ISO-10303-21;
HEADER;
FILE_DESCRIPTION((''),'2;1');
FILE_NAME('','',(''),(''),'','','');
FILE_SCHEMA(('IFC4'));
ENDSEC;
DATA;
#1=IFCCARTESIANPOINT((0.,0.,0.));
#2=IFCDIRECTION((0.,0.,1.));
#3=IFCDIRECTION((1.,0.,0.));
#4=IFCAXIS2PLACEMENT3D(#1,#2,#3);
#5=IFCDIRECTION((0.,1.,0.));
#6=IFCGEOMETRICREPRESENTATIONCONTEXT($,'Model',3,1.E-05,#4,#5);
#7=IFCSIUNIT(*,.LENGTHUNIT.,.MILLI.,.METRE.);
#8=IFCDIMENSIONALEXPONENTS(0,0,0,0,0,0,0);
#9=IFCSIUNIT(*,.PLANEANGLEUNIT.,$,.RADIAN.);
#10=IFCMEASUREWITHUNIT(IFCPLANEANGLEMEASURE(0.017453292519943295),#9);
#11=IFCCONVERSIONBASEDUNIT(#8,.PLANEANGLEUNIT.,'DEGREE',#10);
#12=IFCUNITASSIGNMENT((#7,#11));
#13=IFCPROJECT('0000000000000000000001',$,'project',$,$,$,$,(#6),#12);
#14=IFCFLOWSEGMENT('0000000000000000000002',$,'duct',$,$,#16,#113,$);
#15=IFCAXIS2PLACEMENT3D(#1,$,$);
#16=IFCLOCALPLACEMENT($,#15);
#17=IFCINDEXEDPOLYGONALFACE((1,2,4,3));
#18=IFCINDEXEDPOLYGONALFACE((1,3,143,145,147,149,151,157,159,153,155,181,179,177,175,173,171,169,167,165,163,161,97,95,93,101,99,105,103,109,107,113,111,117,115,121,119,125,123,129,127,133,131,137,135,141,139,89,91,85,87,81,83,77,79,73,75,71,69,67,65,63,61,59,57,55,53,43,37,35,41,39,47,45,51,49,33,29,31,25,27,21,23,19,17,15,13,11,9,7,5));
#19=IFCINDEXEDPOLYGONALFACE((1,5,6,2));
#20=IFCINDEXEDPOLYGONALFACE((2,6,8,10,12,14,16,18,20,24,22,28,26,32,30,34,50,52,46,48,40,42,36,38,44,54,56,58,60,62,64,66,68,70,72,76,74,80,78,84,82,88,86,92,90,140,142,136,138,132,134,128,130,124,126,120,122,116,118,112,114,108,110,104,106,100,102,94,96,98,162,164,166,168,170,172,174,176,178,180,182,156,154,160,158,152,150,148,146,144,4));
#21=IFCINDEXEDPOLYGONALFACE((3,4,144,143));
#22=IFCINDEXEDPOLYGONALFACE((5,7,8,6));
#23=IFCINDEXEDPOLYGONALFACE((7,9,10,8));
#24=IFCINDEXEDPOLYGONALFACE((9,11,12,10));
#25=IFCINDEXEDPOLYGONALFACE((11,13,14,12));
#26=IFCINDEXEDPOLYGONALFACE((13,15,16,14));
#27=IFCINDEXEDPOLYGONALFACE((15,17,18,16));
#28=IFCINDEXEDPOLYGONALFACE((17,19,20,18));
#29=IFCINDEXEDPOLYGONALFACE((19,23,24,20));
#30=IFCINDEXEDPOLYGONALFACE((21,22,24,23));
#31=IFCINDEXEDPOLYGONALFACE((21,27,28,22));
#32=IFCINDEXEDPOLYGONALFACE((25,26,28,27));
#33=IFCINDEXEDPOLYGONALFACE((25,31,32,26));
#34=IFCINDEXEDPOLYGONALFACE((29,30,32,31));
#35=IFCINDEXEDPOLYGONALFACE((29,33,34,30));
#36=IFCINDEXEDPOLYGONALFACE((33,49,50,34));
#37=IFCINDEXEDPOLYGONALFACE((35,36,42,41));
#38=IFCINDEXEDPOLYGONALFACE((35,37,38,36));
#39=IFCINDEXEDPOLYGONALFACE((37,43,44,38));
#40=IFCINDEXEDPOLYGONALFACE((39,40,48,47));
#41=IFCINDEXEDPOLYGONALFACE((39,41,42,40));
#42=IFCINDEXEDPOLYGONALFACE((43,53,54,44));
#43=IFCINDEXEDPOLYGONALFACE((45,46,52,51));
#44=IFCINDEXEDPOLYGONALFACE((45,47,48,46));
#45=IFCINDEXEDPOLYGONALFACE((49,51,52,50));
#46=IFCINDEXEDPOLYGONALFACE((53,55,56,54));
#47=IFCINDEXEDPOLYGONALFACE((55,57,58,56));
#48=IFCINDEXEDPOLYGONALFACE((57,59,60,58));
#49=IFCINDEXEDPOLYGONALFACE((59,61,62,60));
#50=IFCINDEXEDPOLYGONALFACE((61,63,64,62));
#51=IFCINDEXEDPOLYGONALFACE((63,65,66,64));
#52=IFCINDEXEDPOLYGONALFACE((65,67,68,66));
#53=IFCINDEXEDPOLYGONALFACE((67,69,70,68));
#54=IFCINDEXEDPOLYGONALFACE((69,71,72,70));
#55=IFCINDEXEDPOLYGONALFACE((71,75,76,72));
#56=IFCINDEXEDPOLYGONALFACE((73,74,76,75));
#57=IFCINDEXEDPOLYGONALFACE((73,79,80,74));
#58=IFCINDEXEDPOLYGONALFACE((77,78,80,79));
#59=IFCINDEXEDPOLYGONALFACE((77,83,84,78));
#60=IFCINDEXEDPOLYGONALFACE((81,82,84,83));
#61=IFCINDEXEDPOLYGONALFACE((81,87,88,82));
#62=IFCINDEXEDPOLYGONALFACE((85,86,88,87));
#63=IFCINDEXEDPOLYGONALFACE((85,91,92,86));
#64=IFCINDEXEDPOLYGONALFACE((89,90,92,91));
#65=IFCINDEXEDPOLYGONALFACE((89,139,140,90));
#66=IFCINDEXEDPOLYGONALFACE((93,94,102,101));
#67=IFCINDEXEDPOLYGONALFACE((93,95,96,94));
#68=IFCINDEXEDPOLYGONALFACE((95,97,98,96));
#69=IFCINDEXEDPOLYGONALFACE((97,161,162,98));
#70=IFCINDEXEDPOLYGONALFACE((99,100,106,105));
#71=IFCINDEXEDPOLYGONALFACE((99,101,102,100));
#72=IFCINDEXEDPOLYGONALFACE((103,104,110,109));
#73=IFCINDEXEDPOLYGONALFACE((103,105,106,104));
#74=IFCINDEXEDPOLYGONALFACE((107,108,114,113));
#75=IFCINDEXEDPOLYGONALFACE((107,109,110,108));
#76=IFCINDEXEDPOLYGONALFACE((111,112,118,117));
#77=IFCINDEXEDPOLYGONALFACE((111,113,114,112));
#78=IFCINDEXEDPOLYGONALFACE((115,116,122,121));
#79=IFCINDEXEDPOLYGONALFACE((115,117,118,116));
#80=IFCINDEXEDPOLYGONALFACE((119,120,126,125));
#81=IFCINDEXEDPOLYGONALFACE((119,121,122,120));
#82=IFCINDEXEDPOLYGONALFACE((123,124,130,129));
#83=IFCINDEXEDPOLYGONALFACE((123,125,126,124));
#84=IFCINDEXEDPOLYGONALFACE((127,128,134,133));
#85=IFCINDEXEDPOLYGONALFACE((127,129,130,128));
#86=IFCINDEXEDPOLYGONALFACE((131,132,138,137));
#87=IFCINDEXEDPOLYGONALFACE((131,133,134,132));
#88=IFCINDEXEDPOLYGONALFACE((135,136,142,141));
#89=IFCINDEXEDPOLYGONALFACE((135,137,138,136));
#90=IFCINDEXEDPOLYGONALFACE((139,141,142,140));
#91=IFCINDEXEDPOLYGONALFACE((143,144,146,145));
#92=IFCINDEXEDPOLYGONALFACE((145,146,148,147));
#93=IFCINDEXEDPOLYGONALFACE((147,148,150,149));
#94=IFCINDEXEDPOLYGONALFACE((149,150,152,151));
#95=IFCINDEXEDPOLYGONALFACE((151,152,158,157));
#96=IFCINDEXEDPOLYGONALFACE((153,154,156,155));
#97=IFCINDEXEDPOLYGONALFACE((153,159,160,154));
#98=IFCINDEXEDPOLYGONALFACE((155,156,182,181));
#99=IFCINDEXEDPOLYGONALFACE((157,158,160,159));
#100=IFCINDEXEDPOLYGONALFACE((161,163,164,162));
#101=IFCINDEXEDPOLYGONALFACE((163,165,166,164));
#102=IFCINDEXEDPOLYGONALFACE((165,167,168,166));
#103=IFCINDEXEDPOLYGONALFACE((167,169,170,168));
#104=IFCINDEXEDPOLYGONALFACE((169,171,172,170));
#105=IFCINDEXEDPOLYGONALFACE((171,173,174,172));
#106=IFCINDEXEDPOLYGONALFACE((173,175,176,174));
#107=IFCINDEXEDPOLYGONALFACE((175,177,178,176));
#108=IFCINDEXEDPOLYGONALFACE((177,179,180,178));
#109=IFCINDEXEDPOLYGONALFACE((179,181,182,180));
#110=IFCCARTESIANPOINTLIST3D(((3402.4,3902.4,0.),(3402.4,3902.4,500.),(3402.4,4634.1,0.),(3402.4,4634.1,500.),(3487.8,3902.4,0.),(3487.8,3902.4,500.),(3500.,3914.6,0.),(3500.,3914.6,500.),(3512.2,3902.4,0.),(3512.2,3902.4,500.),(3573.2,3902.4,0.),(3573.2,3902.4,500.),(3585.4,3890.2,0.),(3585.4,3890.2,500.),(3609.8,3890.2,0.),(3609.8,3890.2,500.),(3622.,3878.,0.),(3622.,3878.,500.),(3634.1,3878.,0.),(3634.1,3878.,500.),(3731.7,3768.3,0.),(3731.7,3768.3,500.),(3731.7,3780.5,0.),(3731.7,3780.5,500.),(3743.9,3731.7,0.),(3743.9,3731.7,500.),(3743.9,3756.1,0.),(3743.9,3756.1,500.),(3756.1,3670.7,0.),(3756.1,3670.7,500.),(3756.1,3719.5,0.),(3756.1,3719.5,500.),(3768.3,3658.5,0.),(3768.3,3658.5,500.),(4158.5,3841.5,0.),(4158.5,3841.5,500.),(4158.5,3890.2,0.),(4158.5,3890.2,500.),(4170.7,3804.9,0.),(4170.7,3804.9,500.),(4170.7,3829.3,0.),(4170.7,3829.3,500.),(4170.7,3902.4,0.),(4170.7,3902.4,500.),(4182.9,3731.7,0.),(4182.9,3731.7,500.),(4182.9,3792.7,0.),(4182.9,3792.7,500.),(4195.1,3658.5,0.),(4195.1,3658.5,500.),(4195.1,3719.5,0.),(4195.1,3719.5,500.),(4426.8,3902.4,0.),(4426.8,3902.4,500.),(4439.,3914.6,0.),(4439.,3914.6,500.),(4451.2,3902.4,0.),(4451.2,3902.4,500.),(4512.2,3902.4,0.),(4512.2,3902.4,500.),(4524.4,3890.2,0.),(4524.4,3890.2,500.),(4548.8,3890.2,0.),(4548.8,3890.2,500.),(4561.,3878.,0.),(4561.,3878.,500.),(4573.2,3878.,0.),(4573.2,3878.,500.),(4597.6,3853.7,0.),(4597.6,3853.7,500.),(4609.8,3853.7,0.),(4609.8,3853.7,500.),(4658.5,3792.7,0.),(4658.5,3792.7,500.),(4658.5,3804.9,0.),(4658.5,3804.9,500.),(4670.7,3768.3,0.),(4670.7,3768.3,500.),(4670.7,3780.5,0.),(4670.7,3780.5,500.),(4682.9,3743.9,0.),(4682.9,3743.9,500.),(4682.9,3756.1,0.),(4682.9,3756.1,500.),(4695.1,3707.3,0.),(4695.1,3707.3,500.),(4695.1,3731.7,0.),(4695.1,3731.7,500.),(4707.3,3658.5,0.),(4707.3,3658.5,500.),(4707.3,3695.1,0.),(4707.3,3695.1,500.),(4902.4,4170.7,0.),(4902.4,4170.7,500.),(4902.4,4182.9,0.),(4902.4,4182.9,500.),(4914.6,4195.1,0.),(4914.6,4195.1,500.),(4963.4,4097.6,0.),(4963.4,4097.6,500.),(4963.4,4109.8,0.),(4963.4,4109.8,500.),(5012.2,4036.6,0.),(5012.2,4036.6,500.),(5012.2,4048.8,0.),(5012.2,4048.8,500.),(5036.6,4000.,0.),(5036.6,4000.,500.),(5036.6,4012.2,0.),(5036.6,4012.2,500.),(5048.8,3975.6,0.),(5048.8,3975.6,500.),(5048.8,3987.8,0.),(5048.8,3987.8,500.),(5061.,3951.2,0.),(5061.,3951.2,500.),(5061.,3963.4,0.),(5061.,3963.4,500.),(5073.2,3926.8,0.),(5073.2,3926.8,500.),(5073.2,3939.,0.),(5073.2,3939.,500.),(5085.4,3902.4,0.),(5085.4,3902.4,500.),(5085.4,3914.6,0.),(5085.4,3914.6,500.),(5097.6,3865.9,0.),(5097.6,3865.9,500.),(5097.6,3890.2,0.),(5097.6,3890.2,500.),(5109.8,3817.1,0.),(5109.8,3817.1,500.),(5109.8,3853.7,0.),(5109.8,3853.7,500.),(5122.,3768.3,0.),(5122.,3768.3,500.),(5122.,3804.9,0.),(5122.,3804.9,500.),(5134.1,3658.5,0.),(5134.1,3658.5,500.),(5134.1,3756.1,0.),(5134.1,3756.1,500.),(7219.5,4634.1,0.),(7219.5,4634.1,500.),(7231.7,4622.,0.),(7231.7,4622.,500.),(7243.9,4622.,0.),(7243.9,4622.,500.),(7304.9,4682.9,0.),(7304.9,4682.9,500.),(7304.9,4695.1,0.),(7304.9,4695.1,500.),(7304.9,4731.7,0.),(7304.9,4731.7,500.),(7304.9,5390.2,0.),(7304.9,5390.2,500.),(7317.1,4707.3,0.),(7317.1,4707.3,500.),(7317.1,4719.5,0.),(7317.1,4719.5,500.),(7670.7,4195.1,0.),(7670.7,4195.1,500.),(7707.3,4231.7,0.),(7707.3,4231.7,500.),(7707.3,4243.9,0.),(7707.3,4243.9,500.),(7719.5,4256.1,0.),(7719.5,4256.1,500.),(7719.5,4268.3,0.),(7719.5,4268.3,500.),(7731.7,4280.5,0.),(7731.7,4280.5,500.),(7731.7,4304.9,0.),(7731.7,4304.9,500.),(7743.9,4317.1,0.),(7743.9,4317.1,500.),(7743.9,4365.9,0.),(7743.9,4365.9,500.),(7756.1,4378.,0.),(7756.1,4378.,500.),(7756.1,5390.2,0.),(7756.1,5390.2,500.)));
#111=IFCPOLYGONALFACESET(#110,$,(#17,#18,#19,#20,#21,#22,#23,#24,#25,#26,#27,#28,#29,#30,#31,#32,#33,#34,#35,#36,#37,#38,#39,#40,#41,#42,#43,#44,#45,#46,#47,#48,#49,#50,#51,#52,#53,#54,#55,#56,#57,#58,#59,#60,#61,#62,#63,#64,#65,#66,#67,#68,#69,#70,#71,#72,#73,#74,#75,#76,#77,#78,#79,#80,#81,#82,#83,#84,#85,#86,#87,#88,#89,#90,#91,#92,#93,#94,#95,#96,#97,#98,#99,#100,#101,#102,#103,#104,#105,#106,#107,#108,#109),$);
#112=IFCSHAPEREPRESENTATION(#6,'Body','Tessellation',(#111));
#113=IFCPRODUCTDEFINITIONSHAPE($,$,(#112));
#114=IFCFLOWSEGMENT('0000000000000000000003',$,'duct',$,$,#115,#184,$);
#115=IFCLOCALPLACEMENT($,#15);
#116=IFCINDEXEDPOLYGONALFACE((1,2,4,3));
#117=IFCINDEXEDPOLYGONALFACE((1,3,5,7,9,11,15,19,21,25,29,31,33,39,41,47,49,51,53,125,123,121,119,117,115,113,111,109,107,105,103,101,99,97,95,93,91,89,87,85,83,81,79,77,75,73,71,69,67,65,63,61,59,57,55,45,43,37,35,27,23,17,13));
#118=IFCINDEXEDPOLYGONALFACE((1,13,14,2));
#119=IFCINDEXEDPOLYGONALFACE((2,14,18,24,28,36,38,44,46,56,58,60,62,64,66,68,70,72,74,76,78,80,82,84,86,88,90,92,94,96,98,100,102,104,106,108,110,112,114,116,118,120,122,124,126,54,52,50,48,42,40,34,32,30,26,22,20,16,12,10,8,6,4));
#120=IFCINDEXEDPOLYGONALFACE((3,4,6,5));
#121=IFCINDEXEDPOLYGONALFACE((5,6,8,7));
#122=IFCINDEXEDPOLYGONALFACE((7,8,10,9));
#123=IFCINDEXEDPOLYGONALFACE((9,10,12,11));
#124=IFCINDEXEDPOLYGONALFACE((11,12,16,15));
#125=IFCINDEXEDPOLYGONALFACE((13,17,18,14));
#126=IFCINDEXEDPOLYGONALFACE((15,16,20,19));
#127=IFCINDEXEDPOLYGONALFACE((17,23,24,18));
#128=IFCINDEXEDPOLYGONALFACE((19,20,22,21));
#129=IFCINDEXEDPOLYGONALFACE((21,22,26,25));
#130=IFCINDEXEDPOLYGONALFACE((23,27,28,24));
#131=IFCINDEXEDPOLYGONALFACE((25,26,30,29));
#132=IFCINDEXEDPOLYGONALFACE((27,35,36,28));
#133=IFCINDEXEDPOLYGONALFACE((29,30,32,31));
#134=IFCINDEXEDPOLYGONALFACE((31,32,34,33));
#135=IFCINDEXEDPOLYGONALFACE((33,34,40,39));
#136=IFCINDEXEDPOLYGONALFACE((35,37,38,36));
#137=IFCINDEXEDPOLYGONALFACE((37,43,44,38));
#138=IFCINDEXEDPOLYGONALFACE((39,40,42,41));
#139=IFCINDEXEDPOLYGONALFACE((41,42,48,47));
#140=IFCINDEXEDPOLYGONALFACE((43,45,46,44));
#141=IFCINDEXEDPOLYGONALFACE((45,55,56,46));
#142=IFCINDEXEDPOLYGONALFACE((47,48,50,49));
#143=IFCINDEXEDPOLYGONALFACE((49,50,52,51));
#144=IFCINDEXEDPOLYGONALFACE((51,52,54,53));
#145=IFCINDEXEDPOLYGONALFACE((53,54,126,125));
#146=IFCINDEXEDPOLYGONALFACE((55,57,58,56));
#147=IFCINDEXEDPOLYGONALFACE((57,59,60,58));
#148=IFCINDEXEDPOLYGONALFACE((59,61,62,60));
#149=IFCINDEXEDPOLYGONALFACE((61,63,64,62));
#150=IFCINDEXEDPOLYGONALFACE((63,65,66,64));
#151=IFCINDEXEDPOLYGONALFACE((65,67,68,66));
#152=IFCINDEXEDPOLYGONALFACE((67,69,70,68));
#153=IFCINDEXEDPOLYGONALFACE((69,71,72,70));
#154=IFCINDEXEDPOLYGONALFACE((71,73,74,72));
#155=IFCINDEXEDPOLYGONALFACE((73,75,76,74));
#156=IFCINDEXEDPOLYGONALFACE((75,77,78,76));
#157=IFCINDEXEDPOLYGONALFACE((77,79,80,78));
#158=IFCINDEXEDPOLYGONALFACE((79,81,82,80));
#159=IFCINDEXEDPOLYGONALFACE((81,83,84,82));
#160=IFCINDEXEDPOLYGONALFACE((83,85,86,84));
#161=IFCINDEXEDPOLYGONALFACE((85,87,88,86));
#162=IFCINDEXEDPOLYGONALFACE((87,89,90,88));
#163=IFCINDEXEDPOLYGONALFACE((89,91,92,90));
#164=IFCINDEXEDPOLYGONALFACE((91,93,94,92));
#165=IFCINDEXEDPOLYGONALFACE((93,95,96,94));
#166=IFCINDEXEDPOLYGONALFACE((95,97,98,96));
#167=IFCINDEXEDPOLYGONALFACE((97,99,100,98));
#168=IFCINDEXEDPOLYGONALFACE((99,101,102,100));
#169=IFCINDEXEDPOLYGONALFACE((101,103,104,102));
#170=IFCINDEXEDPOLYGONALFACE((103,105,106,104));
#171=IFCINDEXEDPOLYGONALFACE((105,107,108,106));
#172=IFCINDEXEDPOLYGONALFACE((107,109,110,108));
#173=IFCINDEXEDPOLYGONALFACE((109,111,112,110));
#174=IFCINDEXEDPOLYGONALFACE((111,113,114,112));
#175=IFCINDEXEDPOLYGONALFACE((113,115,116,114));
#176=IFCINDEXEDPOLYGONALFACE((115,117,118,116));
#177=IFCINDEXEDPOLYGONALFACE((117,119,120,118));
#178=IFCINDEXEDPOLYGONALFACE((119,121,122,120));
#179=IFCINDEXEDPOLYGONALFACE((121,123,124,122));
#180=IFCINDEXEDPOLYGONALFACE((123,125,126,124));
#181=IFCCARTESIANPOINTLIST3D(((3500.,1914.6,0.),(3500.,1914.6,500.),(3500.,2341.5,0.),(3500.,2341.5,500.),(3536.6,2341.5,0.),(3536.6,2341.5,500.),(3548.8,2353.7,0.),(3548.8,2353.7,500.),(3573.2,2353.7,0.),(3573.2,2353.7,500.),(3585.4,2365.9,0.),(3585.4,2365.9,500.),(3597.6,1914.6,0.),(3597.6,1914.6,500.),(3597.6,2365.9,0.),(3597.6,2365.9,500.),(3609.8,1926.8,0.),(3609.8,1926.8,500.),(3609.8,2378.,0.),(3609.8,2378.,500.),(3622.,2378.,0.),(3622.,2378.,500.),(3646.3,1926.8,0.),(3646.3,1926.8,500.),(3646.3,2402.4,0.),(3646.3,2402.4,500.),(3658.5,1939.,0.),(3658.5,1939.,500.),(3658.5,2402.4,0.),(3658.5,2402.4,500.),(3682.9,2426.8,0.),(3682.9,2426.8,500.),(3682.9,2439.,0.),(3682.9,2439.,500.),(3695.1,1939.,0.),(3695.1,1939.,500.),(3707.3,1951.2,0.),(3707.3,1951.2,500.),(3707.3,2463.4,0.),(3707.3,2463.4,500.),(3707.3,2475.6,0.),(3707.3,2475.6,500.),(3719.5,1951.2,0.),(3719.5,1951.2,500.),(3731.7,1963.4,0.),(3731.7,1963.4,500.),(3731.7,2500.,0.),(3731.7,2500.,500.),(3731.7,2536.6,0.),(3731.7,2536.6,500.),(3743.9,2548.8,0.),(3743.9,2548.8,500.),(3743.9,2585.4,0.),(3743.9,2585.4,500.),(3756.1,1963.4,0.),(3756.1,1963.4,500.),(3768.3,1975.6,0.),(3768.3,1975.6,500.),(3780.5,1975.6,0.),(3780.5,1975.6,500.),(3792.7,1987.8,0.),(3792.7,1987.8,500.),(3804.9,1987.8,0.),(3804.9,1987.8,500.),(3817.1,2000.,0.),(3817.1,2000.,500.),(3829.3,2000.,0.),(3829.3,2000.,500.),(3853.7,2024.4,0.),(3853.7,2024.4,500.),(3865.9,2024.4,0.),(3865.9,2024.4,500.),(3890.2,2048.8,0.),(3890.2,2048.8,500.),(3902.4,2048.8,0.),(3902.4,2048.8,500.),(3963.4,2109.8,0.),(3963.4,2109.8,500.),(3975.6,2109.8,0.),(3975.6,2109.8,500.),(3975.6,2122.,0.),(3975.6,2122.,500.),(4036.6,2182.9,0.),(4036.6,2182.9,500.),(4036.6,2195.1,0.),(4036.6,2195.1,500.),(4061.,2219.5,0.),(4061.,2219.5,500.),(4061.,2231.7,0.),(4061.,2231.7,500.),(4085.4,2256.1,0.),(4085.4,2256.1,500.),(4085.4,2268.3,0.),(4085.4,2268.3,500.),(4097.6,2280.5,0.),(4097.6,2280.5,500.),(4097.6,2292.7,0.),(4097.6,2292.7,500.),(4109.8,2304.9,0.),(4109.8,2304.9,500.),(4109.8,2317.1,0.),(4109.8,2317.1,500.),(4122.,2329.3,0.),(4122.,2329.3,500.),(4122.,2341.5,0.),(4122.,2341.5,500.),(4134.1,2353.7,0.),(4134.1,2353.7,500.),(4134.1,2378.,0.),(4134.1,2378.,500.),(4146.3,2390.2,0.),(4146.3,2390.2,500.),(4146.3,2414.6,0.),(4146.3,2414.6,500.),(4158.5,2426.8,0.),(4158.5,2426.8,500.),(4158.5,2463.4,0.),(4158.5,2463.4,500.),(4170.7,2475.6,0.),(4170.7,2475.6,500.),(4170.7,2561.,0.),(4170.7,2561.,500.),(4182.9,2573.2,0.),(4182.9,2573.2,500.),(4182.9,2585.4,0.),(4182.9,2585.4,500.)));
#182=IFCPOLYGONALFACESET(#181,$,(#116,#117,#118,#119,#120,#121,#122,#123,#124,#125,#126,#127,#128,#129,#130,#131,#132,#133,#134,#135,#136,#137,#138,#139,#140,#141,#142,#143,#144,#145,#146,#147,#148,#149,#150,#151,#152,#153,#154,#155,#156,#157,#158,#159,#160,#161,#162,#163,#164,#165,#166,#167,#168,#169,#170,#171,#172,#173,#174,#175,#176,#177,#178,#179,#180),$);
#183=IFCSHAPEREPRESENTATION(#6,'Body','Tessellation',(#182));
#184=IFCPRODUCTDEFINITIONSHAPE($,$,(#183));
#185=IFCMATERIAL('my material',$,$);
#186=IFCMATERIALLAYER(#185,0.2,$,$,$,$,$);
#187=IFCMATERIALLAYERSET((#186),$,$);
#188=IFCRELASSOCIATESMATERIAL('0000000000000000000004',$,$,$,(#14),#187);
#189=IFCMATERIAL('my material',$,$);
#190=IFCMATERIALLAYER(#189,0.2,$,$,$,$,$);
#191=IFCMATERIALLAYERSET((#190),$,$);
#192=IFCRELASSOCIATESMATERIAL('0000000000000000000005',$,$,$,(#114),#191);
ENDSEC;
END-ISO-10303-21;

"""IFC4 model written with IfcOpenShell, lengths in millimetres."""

from ifc_helpers import new_model, entity, si_unit, converted_unit, direction, origin_with_axes, place, context, project, polyline, outline, extrude, material, layer, layer_set, layer_usage, element, save


model = new_model("IFC4")

# Units and contexts
model_context = context("Model", 3, precision=1e-05, world=origin_with_axes(), true_north=direction((0.0, 1.0, 0.0)))
ifc_project = project(units=[si_unit("LENGTHUNIT", "METRE", prefix="MILLI"), converted_unit("PLANEANGLEUNIT", "DEGREE", entity("IfcPlaneAngleMeasure", 0.017453292519943295), si_unit("PLANEANGLEUNIT", "RADIAN"), dimensions=[0, 0, 0, 0, 0, 0, 0])], contexts=[model_context])

# Flow segments
ifc_material_1 = material(Name="my material")
ifc_layer_1 = layer(ifc_material_1, 0.2)
ifc_layer_set_1 = layer_set([ifc_layer_1])
ifc_layer_usage_1 = layer_usage(ifc_layer_set_1, "AXIS2", "POSITIVE", -0.1)
flow_segment_1_placement = place(None, origin_with_axes())
element("IfcFlowSegment", 1, at=flow_segment_1_placement, material=ifc_layer_usage_1, Name="duct", context=model_context, shape_type="SweptSolid", body=[
    extrude(outline(polyline([(3402.4, 3902.4), (3487.8, 3902.4), (3500.0, 3914.6), (3512.2, 3902.4), (3573.2, 3902.4), (3585.4, 3890.2), (3609.8, 3890.2), (3622.0, 3878.0), (3634.1, 3878.0), (3731.7, 3780.5), (3731.7, 3768.3), (3743.9, 3756.1), (3743.9, 3731.7), (3756.1, 3719.5), (3756.1, 3670.7), (3768.3, 3658.5), (4195.1, 3658.5), (4195.1, 3719.5), (4182.9, 3731.7), (4182.9, 3792.7), (4170.7, 3804.9), (4170.7, 3829.3), (4158.5, 3841.5), (4158.5, 3890.2), (4170.7, 3902.4), (4426.8, 3902.4), (4439.0, 3914.6), (4451.2, 3902.4), (4512.2, 3902.4), (4524.4, 3890.2), (4548.8, 3890.2), (4561.0, 3878.0), (4573.2, 3878.0), (4597.6, 3853.7), (4609.8, 3853.7), (4658.5, 3804.9), (4658.5, 3792.7), (4670.7, 3780.5), (4670.7, 3768.3), (4682.9, 3756.1), (4682.9, 3743.9), (4695.1, 3731.7), (4695.1, 3707.3), (4707.3, 3695.1), (4707.3, 3658.5), (5134.1, 3658.5), (5134.1, 3756.1), (5122.0, 3768.3), (5122.0, 3804.9), (5109.8, 3817.1), (5109.8, 3853.7), (5097.6, 3865.9), (5097.6, 3890.2), (5085.4, 3902.4), (5085.4, 3914.6), (5073.2, 3926.8), (5073.2, 3939.0), (5061.0, 3951.2), (5061.0, 3963.4), (5048.8, 3975.6), (5048.8, 3987.8), (5036.6, 4000.0), (5036.6, 4012.2), (5012.2, 4036.6), (5012.2, 4048.8), (4963.4, 4097.6), (4963.4, 4109.8), (4902.4, 4170.7), (4902.4, 4182.9), (4914.6, 4195.1), (7670.7, 4195.1), (7707.3, 4231.7), (7707.3, 4243.9), (7719.5, 4256.1), (7719.5, 4268.3), (7731.7, 4280.5), (7731.7, 4304.9), (7743.9, 4317.1), (7743.9, 4365.9), (7756.1, 4378.0), (7756.1, 5390.2), (7304.9, 5390.2), (7304.9, 4731.7), (7317.1, 4719.5), (7317.1, 4707.3), (7304.9, 4695.1), (7304.9, 4682.9), (7243.9, 4622.0), (7231.7, 4622.0), (7219.5, 4634.1), (3402.4, 4634.1), (3402.4, 3902.4)])), origin_with_axes(), (0.0, 0.0, 1.0), 500.0),
])
ifc_material_2 = material(Name="my material")
ifc_layer_2 = layer(ifc_material_2, 0.2)
ifc_layer_set_2 = layer_set([ifc_layer_2])
ifc_layer_usage_2 = layer_usage(ifc_layer_set_2, "AXIS2", "POSITIVE", -0.1)
flow_segment_2_placement = place(None, origin_with_axes())
element("IfcFlowSegment", 2, at=flow_segment_2_placement, material=ifc_layer_usage_2, Name="duct", context=model_context, shape_type="SweptSolid", body=[
    extrude(outline(polyline([(3500.0, 1914.6), (3597.6, 1914.6), (3609.8, 1926.8), (3646.3, 1926.8), (3658.5, 1939.0), (3695.1, 1939.0), (3707.3, 1951.2), (3719.5, 1951.2), (3731.7, 1963.4), (3756.1, 1963.4), (3768.3, 1975.6), (3780.5, 1975.6), (3792.7, 1987.8), (3804.9, 1987.8), (3817.1, 2000.0), (3829.3, 2000.0), (3853.7, 2024.4), (3865.9, 2024.4), (3890.2, 2048.8), (3902.4, 2048.8), (3963.4, 2109.8), (3975.6, 2109.8), (3975.6, 2122.0), (4036.6, 2182.9), (4036.6, 2195.1), (4061.0, 2219.5), (4061.0, 2231.7), (4085.4, 2256.1), (4085.4, 2268.3), (4097.6, 2280.5), (4097.6, 2292.7), (4109.8, 2304.9), (4109.8, 2317.1), (4122.0, 2329.3), (4122.0, 2341.5), (4134.1, 2353.7), (4134.1, 2378.0), (4146.3, 2390.2), (4146.3, 2414.6), (4158.5, 2426.8), (4158.5, 2463.4), (4170.7, 2475.6), (4170.7, 2561.0), (4182.9, 2573.2), (4182.9, 2585.4), (3743.9, 2585.4), (3743.9, 2548.8), (3731.7, 2536.6), (3731.7, 2500.0), (3707.3, 2475.6), (3707.3, 2463.4), (3682.9, 2439.0), (3682.9, 2426.8), (3658.5, 2402.4), (3646.3, 2402.4), (3622.0, 2378.0), (3609.8, 2378.0), (3597.6, 2365.9), (3585.4, 2365.9), (3573.2, 2353.7), (3548.8, 2353.7), (3536.6, 2341.5), (3500.0, 2341.5), (3500.0, 1914.6)])), origin_with_axes(), (0.0, 0.0, 1.0), 500.0),
])

save(model, "model.ifc")
